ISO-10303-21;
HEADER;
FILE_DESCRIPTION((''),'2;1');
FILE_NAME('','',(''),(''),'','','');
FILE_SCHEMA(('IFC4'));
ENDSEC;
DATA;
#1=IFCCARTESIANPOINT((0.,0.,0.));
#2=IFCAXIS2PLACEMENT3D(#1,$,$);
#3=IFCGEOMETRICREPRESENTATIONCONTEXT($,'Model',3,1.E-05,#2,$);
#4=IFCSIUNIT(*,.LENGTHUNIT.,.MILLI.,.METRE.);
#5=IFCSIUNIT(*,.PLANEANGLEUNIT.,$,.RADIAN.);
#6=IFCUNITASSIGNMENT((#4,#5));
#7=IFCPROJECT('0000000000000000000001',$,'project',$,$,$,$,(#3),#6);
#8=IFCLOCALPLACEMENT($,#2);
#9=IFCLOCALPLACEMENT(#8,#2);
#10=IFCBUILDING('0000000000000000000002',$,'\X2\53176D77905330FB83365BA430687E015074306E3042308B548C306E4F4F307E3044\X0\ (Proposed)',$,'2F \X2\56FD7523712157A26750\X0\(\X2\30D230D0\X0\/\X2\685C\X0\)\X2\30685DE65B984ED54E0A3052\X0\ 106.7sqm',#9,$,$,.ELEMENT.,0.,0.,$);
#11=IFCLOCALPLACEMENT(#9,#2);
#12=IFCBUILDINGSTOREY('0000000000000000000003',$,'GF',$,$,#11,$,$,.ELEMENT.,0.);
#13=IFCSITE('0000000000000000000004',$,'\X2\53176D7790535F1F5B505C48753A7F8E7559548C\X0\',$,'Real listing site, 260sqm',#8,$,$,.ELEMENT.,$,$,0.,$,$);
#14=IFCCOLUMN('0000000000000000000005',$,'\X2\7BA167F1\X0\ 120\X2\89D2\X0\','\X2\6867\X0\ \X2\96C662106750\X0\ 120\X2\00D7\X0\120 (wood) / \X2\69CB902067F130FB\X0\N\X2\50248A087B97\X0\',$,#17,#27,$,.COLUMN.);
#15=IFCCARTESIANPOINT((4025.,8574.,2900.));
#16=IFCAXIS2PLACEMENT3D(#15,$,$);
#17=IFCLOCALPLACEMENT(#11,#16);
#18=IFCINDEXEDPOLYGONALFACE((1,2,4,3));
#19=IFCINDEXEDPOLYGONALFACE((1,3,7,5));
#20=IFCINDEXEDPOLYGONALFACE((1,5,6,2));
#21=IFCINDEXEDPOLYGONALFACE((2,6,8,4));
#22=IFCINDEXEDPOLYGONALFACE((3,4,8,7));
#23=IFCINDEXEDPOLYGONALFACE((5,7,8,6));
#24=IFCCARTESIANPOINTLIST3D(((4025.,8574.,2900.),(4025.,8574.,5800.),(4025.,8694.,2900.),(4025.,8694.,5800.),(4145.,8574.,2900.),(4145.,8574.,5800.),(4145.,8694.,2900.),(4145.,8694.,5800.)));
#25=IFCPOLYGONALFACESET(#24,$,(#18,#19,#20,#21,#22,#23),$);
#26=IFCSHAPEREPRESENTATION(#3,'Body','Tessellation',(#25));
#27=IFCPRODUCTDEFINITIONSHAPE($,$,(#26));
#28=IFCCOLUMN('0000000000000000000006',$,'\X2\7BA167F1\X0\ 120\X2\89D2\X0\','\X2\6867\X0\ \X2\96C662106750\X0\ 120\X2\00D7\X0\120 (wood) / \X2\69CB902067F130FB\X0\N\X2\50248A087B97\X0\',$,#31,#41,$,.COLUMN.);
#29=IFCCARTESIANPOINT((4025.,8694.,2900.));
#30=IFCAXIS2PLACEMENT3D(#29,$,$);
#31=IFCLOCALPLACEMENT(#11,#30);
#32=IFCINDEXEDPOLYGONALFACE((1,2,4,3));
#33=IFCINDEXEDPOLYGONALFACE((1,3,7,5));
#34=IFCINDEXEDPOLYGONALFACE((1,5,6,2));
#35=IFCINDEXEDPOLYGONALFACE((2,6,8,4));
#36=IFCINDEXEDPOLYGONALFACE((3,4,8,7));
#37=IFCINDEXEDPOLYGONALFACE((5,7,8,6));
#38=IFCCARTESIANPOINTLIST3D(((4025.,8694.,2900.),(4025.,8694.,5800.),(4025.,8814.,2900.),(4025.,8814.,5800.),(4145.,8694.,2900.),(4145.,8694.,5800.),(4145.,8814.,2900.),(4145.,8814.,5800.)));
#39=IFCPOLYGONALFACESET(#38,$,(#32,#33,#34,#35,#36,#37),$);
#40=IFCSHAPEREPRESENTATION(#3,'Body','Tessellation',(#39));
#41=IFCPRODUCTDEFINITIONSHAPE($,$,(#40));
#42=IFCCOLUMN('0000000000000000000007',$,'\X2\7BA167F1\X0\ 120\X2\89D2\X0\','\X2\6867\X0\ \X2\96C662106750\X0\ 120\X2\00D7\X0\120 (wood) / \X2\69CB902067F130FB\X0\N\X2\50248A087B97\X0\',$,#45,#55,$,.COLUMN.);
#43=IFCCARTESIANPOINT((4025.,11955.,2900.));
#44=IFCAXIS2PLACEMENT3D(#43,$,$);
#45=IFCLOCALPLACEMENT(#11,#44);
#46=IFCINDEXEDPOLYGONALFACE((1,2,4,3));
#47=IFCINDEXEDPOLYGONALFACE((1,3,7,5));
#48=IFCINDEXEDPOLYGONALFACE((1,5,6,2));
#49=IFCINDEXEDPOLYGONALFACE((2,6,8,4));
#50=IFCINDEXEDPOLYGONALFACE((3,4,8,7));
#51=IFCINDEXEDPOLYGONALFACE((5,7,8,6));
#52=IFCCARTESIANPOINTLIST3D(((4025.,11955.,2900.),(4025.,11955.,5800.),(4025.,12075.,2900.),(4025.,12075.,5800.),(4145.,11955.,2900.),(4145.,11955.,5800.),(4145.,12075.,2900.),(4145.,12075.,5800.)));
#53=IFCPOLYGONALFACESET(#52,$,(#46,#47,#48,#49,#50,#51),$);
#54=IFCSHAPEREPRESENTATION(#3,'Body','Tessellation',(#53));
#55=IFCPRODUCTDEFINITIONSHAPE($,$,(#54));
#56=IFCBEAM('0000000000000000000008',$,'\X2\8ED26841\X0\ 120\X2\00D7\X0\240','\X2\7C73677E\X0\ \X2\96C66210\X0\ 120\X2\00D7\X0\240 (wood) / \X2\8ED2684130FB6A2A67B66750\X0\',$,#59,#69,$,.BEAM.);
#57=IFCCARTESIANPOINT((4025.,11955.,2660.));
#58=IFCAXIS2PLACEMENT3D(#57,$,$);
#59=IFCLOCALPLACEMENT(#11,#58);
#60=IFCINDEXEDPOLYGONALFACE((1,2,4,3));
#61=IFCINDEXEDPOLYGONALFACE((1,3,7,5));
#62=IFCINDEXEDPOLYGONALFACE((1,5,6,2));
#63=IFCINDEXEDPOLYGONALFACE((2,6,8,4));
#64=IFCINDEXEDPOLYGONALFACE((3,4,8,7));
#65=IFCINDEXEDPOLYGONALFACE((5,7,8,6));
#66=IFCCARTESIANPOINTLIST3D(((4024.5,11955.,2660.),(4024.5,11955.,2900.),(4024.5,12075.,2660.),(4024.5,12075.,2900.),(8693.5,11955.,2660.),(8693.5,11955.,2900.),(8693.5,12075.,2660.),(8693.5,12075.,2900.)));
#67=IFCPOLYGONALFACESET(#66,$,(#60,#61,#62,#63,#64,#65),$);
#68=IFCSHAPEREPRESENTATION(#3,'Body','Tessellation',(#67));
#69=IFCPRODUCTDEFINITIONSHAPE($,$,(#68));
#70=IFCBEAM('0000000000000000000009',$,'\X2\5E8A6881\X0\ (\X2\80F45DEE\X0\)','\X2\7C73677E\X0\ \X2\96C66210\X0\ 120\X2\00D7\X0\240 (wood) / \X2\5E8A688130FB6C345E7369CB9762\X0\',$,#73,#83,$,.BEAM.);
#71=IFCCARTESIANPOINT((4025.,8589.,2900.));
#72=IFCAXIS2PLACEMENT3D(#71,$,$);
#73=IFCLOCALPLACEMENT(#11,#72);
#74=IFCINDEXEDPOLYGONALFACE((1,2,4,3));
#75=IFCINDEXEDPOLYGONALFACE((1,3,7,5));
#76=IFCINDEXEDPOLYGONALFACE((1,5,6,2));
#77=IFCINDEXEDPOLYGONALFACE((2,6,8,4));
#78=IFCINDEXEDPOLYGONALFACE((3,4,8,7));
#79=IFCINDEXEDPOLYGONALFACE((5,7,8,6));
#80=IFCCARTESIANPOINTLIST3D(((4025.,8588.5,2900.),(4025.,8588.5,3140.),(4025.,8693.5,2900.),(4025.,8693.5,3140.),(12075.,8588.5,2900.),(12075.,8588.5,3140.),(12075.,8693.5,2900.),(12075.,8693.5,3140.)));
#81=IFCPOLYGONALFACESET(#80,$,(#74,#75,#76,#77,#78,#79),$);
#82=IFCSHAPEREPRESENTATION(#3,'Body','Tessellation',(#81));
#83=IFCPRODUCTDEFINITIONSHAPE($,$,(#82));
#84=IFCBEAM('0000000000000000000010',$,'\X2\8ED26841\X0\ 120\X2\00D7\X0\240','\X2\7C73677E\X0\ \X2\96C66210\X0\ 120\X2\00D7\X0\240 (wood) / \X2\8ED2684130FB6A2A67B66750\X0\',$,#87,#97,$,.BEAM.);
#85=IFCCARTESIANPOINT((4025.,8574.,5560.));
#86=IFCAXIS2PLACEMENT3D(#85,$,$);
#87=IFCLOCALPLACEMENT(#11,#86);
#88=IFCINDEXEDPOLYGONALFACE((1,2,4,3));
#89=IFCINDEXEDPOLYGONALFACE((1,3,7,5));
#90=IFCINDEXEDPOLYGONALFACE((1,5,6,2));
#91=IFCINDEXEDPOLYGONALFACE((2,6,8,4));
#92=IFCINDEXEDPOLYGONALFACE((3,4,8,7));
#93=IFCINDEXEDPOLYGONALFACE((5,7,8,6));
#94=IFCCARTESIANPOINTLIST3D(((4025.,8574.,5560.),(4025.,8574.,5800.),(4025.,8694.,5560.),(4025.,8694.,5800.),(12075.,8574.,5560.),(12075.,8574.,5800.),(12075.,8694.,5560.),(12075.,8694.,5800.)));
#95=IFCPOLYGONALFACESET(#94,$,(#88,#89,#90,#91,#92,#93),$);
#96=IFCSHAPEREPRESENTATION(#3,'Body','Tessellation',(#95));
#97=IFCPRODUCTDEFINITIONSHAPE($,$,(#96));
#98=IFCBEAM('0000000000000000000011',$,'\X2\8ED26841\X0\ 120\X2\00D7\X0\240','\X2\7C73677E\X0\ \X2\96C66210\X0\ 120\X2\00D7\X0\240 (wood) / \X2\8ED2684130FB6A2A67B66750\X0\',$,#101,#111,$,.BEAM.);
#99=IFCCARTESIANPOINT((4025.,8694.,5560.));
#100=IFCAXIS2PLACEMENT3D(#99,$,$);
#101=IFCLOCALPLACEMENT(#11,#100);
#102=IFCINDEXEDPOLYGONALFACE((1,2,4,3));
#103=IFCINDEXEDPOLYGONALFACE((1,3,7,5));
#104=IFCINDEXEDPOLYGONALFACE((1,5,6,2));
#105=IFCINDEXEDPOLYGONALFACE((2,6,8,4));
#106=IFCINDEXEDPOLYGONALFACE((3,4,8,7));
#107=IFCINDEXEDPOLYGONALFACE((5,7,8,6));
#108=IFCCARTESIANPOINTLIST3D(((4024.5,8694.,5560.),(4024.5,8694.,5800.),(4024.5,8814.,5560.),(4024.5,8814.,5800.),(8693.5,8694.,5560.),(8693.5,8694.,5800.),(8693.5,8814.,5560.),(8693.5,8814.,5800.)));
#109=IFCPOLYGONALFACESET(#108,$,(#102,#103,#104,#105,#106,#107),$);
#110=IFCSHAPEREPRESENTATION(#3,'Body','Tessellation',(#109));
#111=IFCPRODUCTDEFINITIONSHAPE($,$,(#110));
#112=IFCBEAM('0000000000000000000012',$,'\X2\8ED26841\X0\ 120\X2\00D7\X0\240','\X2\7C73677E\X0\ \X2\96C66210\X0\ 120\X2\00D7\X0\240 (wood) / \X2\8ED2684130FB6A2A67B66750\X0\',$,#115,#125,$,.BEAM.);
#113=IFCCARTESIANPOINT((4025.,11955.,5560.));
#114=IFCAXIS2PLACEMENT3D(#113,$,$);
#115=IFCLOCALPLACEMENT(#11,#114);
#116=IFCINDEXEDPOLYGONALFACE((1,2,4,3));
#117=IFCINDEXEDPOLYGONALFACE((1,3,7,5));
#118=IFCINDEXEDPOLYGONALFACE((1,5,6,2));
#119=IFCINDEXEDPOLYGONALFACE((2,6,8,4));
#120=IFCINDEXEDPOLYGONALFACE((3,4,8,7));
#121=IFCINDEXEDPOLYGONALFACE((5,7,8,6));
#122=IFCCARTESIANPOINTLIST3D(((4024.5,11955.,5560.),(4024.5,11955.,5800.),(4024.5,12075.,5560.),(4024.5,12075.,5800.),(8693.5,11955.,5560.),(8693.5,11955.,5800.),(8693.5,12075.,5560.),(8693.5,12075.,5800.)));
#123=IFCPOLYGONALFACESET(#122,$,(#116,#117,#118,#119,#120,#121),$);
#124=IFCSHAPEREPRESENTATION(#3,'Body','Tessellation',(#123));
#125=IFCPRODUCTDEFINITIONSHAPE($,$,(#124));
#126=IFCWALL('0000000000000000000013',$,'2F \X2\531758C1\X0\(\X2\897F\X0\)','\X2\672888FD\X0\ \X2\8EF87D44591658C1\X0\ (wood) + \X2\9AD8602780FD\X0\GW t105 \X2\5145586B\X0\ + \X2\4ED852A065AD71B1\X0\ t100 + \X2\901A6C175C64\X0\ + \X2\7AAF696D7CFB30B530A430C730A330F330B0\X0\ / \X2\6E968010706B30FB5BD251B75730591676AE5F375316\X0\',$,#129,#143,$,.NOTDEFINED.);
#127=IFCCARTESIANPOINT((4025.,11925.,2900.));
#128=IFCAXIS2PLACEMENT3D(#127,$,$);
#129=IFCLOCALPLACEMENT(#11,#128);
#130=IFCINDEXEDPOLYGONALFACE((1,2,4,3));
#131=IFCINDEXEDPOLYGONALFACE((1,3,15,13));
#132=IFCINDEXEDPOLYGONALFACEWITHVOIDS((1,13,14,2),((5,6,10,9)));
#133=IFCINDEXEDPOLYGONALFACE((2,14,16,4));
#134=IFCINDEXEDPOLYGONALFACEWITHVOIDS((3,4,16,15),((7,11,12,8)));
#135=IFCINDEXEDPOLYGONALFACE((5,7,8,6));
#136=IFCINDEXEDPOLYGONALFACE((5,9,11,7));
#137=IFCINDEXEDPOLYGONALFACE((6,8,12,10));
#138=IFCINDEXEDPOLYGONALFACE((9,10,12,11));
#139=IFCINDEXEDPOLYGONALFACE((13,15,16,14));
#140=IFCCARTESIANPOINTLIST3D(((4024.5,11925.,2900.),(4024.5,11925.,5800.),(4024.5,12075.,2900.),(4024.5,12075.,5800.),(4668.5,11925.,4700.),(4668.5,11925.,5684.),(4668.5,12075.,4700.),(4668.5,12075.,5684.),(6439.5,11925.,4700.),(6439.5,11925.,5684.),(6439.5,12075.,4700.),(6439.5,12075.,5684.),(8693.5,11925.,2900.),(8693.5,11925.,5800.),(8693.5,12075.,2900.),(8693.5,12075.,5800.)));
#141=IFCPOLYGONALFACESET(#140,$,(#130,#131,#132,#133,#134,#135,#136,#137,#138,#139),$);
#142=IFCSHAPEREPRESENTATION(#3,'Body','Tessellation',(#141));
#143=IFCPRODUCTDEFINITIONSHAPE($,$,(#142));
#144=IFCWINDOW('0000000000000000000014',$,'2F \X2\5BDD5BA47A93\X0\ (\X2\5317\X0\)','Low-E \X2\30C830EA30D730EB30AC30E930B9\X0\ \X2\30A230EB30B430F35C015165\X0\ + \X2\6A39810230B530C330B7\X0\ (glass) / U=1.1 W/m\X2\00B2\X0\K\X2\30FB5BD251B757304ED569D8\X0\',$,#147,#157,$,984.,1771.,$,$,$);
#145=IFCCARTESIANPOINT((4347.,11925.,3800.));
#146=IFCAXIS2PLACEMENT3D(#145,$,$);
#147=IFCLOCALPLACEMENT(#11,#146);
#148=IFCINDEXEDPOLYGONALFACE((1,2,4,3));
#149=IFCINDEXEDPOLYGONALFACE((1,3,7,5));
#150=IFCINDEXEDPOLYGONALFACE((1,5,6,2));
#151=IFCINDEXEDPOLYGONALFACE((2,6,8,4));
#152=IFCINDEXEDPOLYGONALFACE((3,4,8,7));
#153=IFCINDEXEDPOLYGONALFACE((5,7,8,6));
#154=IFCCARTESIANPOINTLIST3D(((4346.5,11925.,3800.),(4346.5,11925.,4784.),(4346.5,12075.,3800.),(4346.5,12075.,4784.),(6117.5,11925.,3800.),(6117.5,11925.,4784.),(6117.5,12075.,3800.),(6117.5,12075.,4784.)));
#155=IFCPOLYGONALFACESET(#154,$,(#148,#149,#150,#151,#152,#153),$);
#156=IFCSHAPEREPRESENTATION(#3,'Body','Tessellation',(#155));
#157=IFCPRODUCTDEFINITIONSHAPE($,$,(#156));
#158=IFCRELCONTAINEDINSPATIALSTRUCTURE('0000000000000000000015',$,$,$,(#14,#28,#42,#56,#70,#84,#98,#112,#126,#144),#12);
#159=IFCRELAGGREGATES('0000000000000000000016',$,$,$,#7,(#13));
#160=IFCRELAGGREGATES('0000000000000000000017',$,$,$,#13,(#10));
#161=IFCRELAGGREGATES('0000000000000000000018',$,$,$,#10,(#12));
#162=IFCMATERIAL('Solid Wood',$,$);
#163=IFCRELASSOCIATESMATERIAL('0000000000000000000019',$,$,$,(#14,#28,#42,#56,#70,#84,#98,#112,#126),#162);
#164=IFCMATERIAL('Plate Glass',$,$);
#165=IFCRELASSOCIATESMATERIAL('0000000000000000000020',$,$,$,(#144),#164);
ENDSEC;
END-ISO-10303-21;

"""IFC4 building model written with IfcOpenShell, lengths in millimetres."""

from ifc_helpers import new_model, si_unit, frame, frame_2d, origin, place, context, project, spatial, rectangle, extrude, material, element, fill, save


model = new_model("IFC4")

# Units and contexts
model_context = context("Model", 3, precision=1e-05, world=origin())
ifc_project = project(units=[si_unit("LENGTHUNIT", "METRE", prefix="MILLI"), si_unit("PLANEANGLEUNIT", "RADIAN")], contexts=[model_context])

# Site, building, storey
site_placement = place(None, origin())
site = spatial("IfcSite", under=ifc_project, at=site_placement, Name="北海道弟子屈町美留和", ObjectType="Real listing site, 260sqm", CompositionType="ELEMENT", RefElevation=0.0)
building_placement = place(site_placement, origin())
building = spatial("IfcBuilding", under=site, at=building_placement, Name="北海道・茶室と縁側のある和の住まい (Proposed)", ObjectType="2F 国産無垢材(ヒバ/桜)と左官仕上げ 106.7sqm", CompositionType="ELEMENT", ElevationOfRefHeight=0.0, ElevationOfTerrain=0.0)
storey_placement = place(building_placement, origin())
storey = spatial("IfcBuildingStorey", under=building, at=storey_placement, Name="GF", CompositionType="ELEMENT", Elevation=0.0)

# Columns
ifc_material_1 = material(Name="Solid Wood")
column_1_placement = place(storey_placement, frame((4025.0, 8574.0, 2900.0)))
element("IfcColumn", 1, at=column_1_placement, inside=storey, material=ifc_material_1, Name="管柱 120角", Description="桧 集成材 120×120 (wood) / 構造柱・N値計算", PredefinedType="COLUMN", context=model_context, shape_type="SweptSolid", body=[
    extrude(rectangle(XDim=120.0, YDim=120.0, at=frame_2d((60.0, 60.0))), frame((4025.0, 8574.0, 2900.0)), (0.0, 0.0, 1.0), 2900.0),
])
column_2_placement = place(storey_placement, frame((4025.0, 8694.0, 2900.0)))
element("IfcColumn", 2, at=column_2_placement, inside=storey, material=ifc_material_1, Name="管柱 120角", Description="桧 集成材 120×120 (wood) / 構造柱・N値計算", PredefinedType="COLUMN", context=model_context, shape_type="SweptSolid", body=[
    extrude(rectangle(XDim=120.0, YDim=120.0, at=frame_2d((60.0, 60.0))), frame((4025.0, 8694.0, 2900.0)), (0.0, 0.0, 1.0), 2900.0),
])
column_3_placement = place(storey_placement, frame((4025.0, 11955.0, 2900.0)))
element("IfcColumn", 3, at=column_3_placement, inside=storey, material=ifc_material_1, Name="管柱 120角", Description="桧 集成材 120×120 (wood) / 構造柱・N値計算", PredefinedType="COLUMN", context=model_context, shape_type="SweptSolid", body=[
    extrude(rectangle(XDim=120.0, YDim=120.0, at=frame_2d((60.0, 60.0))), frame((4025.0, 11955.0, 2900.0)), (0.0, 0.0, 1.0), 2900.0),
])

# Beams
beam_1_placement = place(storey_placement, frame((4025.0, 11955.0, 2660.0)))
element("IfcBeam", 4, at=beam_1_placement, inside=storey, material=ifc_material_1, Name="軒桁 120×240", Description="米松 集成 120×240 (wood) / 軒桁・横架材", PredefinedType="BEAM", context=model_context, shape_type="SweptSolid", body=[
    extrude(rectangle(XDim=4669.0, YDim=120.0, at=frame_2d((2334.0, 60.0))), frame((4025.0, 11955.0, 2660.0)), (0.0, 0.0, 1.0), 240.0),
])
beam_2_placement = place(storey_placement, frame((4025.0, 8589.0, 2900.0)))
element("IfcBeam", 5, at=beam_2_placement, inside=storey, material=ifc_material_1, Name="床梁 (胴差)", Description="米松 集成 120×240 (wood) / 床梁・水平構面", PredefinedType="BEAM", context=model_context, shape_type="SweptSolid", body=[
    extrude(rectangle(XDim=8050.0, YDim=105.0, at=frame_2d((4025.0, 52.0))), frame((4025.0, 8589.0, 2900.0)), (0.0, 0.0, 1.0), 240.0),
])
beam_3_placement = place(storey_placement, frame((4025.0, 8574.0, 5560.0)))
element("IfcBeam", 6, at=beam_3_placement, inside=storey, material=ifc_material_1, Name="軒桁 120×240", Description="米松 集成 120×240 (wood) / 軒桁・横架材", PredefinedType="BEAM", context=model_context, shape_type="SweptSolid", body=[
    extrude(rectangle(XDim=8050.0, YDim=120.0, at=frame_2d((4025.0, 60.0))), frame((4025.0, 8574.0, 5560.0)), (0.0, 0.0, 1.0), 240.0),
])
beam_4_placement = place(storey_placement, frame((4025.0, 8694.0, 5560.0)))
element("IfcBeam", 7, at=beam_4_placement, inside=storey, material=ifc_material_1, Name="軒桁 120×240", Description="米松 集成 120×240 (wood) / 軒桁・横架材", PredefinedType="BEAM", context=model_context, shape_type="SweptSolid", body=[
    extrude(rectangle(XDim=4669.0, YDim=120.0, at=frame_2d((2334.0, 60.0))), frame((4025.0, 8694.0, 5560.0)), (0.0, 0.0, 1.0), 240.0),
])
beam_5_placement = place(storey_placement, frame((4025.0, 11955.0, 5560.0)))
element("IfcBeam", 8, at=beam_5_placement, inside=storey, material=ifc_material_1, Name="軒桁 120×240", Description="米松 集成 120×240 (wood) / 軒桁・横架材", PredefinedType="BEAM", context=model_context, shape_type="SweptSolid", body=[
    extrude(rectangle(XDim=4669.0, YDim=120.0, at=frame_2d((2334.0, 60.0))), frame((4025.0, 11955.0, 5560.0)), (0.0, 0.0, 1.0), 240.0),
])

# Wall, opening, window
wall_1_placement = place(storey_placement, frame((4025.0, 11925.0, 2900.0)))
wall_1 = element("IfcWall", 9, at=wall_1_placement, inside=storey, material=ifc_material_1, Name="2F 北壁(西)", Description="木製 軸組外壁 (wood) + 高性能GW t105 充填 + 付加断熱 t100 + 通気層 + 窯業系サイディング / 準耐火・寒冷地外皮強化", PredefinedType="NOTDEFINED", context=model_context, shape_type="SweptSolid", body=[
    extrude(rectangle(XDim=4669.0, YDim=150.0, at=frame_2d((2334.0, 75.0))), frame((4025.0, 11925.0, 2900.0)), (0.0, 0.0, 1.0), 2900.0),
])
opening_placement = place(storey_placement, frame((4347.0, 11925.0, 3800.0)))
opening = element("IfcOpeningElement", 10, at=opening_placement, cuts=wall_1, PredefinedType="NOTDEFINED", context=model_context, shape_type="SweptSolid", body=[
    extrude(rectangle(XDim=1771.0, YDim=150.0, at=frame_2d((885.0, 75.0))), frame((4347.0, 11925.0, 3800.0)), (0.0, 0.0, 1.0), 984.0),
])
ifc_material_2 = material(Name="Plate Glass")
window_placement = place(storey_placement, frame((4347.0, 11925.0, 3800.0)))
window = element("IfcWindow", 11, at=window_placement, inside=storey, material=ifc_material_2, Name="2F 寝室窓 (北)", Description="Low-E トリプルガラス アルゴン封入 + 樹脂サッシ (glass) / U=1.1 W/m²K・寒冷地仕様", OverallHeight=984.0, OverallWidth=1771.0, context=model_context, shape_type="SweptSolid", body=[
    extrude(rectangle(XDim=1771.0, YDim=150.0, at=frame_2d((885.0, 75.0))), frame((4347.0, 11925.0, 3800.0)), (0.0, 0.0, 1.0), 984.0),
])
fill(opening, window)

save(model, "model.ifc")
